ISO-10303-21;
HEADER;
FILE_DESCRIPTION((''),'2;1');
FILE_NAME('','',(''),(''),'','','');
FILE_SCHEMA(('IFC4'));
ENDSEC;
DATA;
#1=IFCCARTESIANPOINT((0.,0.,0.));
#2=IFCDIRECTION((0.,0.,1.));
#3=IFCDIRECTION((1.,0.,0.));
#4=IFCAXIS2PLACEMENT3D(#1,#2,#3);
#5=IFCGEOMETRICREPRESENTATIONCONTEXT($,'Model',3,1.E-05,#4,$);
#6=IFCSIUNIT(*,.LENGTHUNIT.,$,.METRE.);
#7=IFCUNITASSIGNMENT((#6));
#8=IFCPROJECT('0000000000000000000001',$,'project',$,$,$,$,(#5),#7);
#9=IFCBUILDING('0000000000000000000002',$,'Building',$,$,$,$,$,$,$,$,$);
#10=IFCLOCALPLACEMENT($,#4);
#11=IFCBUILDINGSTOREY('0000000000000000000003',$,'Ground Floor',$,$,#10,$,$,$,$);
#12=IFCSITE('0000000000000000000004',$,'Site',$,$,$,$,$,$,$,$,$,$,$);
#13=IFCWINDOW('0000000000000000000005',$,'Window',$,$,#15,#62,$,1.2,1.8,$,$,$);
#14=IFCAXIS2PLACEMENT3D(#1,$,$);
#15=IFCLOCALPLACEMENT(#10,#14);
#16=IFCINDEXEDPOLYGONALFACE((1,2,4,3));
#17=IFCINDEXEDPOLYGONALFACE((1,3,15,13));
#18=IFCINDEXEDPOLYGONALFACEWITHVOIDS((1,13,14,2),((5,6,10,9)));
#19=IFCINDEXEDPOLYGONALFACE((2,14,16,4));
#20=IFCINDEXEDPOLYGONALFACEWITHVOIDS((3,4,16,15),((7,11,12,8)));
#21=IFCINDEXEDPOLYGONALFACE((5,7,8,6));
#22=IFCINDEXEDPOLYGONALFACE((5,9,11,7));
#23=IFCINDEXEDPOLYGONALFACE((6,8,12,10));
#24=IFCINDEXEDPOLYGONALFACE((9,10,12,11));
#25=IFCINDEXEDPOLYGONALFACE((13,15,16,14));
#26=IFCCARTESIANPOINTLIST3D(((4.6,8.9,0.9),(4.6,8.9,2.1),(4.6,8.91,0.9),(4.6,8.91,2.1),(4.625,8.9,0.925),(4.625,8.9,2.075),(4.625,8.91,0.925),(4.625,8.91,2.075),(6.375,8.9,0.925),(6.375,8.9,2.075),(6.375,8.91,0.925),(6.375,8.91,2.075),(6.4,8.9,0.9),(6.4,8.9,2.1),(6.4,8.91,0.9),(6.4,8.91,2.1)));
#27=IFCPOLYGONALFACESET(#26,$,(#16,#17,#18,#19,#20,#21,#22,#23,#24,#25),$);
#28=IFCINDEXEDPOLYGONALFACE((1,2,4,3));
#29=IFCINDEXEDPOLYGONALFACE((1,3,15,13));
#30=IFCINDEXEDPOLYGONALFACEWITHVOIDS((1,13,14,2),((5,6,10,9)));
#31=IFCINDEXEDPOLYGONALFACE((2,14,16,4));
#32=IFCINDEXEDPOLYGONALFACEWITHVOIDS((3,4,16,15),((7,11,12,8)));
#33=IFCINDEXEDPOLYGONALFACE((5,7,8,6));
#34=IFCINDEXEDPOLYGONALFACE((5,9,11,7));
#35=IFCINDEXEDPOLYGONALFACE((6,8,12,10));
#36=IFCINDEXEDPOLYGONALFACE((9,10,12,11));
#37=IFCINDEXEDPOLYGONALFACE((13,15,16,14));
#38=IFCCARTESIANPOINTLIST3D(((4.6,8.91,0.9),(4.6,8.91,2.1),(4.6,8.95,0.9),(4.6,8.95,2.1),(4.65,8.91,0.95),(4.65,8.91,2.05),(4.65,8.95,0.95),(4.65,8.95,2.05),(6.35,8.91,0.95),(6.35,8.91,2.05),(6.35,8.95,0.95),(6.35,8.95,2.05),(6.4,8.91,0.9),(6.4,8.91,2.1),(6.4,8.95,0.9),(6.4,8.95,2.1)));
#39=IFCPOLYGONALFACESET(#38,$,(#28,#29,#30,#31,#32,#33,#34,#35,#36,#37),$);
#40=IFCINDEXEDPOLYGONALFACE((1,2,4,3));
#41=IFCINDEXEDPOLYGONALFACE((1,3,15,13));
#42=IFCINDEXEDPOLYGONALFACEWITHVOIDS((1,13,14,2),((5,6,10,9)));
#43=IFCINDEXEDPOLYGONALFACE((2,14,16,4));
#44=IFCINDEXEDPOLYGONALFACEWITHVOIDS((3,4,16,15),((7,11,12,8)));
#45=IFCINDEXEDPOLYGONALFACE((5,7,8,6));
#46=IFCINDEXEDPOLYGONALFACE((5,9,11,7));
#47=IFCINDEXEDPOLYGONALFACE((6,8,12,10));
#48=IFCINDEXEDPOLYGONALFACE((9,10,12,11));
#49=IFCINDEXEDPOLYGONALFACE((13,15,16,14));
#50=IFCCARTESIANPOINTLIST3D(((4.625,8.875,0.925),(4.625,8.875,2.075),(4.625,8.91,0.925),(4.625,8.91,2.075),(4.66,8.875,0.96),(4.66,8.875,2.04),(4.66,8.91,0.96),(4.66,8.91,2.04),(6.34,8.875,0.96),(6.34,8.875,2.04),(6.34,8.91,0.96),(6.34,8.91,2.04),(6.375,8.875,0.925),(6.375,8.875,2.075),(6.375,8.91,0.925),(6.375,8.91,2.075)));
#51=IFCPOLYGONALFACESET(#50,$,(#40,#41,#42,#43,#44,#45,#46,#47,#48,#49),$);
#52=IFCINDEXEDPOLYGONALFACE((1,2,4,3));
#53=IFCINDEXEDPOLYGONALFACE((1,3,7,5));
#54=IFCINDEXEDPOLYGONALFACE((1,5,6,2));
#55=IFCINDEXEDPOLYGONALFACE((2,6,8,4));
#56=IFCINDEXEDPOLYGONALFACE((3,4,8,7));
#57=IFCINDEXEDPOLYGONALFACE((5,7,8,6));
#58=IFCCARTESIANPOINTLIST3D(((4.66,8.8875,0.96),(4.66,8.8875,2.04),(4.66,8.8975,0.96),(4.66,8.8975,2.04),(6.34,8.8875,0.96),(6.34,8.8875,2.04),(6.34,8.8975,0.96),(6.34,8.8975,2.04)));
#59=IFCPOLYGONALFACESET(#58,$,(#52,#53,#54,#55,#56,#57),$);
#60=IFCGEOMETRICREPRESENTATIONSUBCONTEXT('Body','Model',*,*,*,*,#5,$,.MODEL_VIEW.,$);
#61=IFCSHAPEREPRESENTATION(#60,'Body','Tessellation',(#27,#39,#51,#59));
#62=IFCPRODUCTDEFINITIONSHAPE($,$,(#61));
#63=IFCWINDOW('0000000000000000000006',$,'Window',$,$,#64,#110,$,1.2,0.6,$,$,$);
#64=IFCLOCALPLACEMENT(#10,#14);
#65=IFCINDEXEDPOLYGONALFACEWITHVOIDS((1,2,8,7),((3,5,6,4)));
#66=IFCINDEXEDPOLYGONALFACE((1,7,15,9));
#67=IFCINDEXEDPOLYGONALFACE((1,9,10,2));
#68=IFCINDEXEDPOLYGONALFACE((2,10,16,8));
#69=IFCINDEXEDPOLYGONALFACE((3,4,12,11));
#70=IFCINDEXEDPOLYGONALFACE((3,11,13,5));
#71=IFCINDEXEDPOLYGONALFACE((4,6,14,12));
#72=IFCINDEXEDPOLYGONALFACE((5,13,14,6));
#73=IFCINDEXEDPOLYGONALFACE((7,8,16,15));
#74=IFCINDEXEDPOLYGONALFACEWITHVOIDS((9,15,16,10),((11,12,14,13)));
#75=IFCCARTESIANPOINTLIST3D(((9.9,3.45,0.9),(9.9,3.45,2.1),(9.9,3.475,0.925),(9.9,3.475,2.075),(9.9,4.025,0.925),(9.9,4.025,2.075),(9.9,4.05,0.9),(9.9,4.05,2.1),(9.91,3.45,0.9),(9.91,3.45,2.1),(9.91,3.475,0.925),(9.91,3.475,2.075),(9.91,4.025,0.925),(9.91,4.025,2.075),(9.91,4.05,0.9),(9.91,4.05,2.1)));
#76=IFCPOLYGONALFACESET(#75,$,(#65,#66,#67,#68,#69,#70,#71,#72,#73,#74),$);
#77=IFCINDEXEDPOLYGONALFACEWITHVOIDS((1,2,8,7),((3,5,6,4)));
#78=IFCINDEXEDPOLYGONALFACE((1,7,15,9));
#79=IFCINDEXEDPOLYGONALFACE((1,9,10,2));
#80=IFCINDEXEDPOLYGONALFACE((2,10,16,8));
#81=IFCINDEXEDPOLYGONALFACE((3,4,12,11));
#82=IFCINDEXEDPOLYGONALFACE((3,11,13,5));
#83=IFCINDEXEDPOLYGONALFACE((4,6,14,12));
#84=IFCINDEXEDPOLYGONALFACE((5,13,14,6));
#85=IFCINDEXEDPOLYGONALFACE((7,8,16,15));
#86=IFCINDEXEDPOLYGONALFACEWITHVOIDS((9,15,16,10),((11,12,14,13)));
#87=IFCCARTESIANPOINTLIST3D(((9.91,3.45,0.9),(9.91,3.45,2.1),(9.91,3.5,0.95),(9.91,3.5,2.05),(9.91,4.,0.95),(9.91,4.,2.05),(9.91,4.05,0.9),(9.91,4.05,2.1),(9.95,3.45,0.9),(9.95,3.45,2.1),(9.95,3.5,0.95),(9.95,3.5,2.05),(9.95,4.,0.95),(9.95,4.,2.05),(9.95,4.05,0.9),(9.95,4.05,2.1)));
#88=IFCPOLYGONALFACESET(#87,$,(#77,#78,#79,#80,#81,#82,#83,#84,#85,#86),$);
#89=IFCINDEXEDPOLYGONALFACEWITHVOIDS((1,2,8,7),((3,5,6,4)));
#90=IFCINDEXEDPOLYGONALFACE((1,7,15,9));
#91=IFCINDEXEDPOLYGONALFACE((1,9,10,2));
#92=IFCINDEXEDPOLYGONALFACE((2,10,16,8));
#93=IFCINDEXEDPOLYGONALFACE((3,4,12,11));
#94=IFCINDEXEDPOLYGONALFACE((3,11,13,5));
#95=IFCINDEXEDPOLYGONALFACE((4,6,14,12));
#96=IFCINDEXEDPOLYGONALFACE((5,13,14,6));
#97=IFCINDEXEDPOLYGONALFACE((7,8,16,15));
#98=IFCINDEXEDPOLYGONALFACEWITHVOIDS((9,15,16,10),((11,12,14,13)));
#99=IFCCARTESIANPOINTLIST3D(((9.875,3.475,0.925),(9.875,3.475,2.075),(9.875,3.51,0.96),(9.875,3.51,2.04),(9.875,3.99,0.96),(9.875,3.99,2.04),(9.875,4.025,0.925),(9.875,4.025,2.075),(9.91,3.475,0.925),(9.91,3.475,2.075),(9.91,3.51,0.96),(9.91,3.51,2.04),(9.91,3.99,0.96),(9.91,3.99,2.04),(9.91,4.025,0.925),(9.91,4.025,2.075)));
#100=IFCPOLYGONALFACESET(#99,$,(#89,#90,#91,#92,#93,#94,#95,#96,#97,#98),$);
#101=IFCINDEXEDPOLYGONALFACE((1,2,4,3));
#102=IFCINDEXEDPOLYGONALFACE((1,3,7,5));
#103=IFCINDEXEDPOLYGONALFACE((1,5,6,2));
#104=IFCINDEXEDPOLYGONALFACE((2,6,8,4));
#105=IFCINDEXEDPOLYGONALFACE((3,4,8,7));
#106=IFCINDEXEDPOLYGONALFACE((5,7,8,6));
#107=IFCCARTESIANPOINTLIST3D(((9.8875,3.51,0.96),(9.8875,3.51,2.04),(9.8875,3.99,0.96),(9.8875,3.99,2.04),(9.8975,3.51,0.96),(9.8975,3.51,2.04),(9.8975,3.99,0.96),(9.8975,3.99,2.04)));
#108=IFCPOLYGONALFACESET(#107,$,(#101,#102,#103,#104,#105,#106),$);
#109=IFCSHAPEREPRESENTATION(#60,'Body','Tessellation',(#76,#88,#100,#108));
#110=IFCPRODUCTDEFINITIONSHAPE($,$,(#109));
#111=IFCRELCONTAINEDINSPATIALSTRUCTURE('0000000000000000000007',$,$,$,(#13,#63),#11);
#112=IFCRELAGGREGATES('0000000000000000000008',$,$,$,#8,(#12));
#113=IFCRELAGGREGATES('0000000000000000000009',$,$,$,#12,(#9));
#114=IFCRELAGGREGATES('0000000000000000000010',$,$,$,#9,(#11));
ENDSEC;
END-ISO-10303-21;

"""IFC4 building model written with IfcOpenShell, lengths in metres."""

from ifc_helpers import new_model, si_unit, frame, origin_with_axes, place, context, subcontext, project, spatial, line, indexed_curve, outline, extrude, element, save


model = new_model("IFC4")

# Units and contexts
model_context = context("Model", 3, precision=1e-05, world=origin_with_axes())
body_context = subcontext(model_context, "Body", "Model", "MODEL_VIEW")
ifc_project = project(units=[si_unit("LENGTHUNIT", "METRE")], contexts=[model_context])

# Site, building, storey
site = spatial("IfcSite", under=ifc_project, Name="Site")
building = spatial("IfcBuilding", under=site, Name="Building")
storey_placement = place(None, origin_with_axes())
storey = spatial("IfcBuildingStorey", under=building, at=storey_placement, Name="Ground Floor")

# Windows
window_1_placement = place(storey_placement, frame((6.4, 9.0, 0.9), z_axis=(0.0, 0.0, 1.0), x_axis=(-1.0, 0.0, 0.0)))
element("IfcWindow", 1, at=window_1_placement, inside=storey, Name="Window", OverallHeight=1.2, OverallWidth=1.8, context=body_context, shape_type="SweptSolid", body=[
    extrude(outline(indexed_curve([(0.0, 0.0), (1.8, 0.0), (1.8, 1.2), (0.0, 1.2)], segments=[line(1, 2, 3, 4, 1)]), holes=[indexed_curve([(0.025, 0.025), (1.775, 0.025), (1.775, 1.175), (0.025, 1.175)], segments=[line(1, 2, 3, 4, 1)])]), frame((0.0, 0.09, 0.0), z_axis=(0.0, -1.0, 0.0), x_axis=(1.0, 0.0, 0.0)), (0.0, 0.0, -1.0), 0.01),
    extrude(outline(indexed_curve([(0.0, 0.0), (1.8, 0.0), (1.8, 1.2), (0.0, 1.2)], segments=[line(1, 2, 3, 4, 1)]), holes=[indexed_curve([(0.05, 0.05), (1.75, 0.05), (1.75, 1.15), (0.05, 1.15)], segments=[line(1, 2, 3, 4, 1)])]), frame((0.0, 0.05, 0.0), z_axis=(0.0, -1.0, 0.0), x_axis=(1.0, 0.0, 0.0)), (0.0, 0.0, -1.0), 0.04),
    extrude(outline(indexed_curve([(0.0, 0.0), (1.75, 0.0), (1.75, 1.15), (0.0, 1.15)], segments=[line(1, 2, 3, 4, 1)]), holes=[indexed_curve([(0.035, 0.035), (1.715, 0.035), (1.715, 1.115), (0.035, 1.115)], segments=[line(1, 2, 3, 4, 1)])]), frame((0.025, 0.09, 0.025), z_axis=(0.0, -1.0, 0.0), x_axis=(1.0, 0.0, 0.0)), (0.0, 0.0, -1.0), 0.035),
    extrude(outline(indexed_curve([(0.035, 0.035), (1.715, 0.035), (1.715, 1.115), (0.035, 1.115)], segments=[line(1, 2, 3, 4, 1)])), frame((0.025, 0.1025, 0.025), z_axis=(0.0, -1.0, 0.0), x_axis=(1.0, 0.0, 0.0)), (0.0, 0.0, -1.0), 0.01),
])
window_2_placement = place(storey_placement, frame((10.0, 3.45, 0.9), z_axis=(0.0, 0.0, 1.0), x_axis=(0.0, 1.0, 0.0)))
element("IfcWindow", 2, at=window_2_placement, inside=storey, Name="Window", OverallHeight=1.2, OverallWidth=0.6, context=body_context, shape_type="SweptSolid", body=[
    extrude(outline(indexed_curve([(0.0, 0.0), (0.6, 0.0), (0.6, 1.2), (0.0, 1.2)], segments=[line(1, 2, 3, 4, 1)]), holes=[indexed_curve([(0.025, 0.025), (0.575, 0.025), (0.575, 1.175), (0.025, 1.175)], segments=[line(1, 2, 3, 4, 1)])]), frame((0.0, 0.09, 0.0), z_axis=(0.0, -1.0, 0.0), x_axis=(1.0, 0.0, 0.0)), (0.0, 0.0, -1.0), 0.01),
    extrude(outline(indexed_curve([(0.0, 0.0), (0.6, 0.0), (0.6, 1.2), (0.0, 1.2)], segments=[line(1, 2, 3, 4, 1)]), holes=[indexed_curve([(0.05, 0.05), (0.55, 0.05), (0.55, 1.15), (0.05, 1.15)], segments=[line(1, 2, 3, 4, 1)])]), frame((0.0, 0.05, 0.0), z_axis=(0.0, -1.0, 0.0), x_axis=(1.0, 0.0, 0.0)), (0.0, 0.0, -1.0), 0.04),
    extrude(outline(indexed_curve([(0.0, 0.0), (0.55, 0.0), (0.55, 1.15), (0.0, 1.15)], segments=[line(1, 2, 3, 4, 1)]), holes=[indexed_curve([(0.035, 0.035), (0.515, 0.035), (0.515, 1.115), (0.035, 1.115)], segments=[line(1, 2, 3, 4, 1)])]), frame((0.025, 0.09, 0.025), z_axis=(0.0, -1.0, 0.0), x_axis=(1.0, 0.0, 0.0)), (0.0, 0.0, -1.0), 0.035),
    extrude(outline(indexed_curve([(0.035, 0.035), (0.515, 0.035), (0.515, 1.115), (0.035, 1.115)], segments=[line(1, 2, 3, 4, 1)])), frame((0.025, 0.1025, 0.025), z_axis=(0.0, -1.0, 0.0), x_axis=(1.0, 0.0, 0.0)), (0.0, 0.0, -1.0), 0.01),
])

save(model, "model.ifc")
